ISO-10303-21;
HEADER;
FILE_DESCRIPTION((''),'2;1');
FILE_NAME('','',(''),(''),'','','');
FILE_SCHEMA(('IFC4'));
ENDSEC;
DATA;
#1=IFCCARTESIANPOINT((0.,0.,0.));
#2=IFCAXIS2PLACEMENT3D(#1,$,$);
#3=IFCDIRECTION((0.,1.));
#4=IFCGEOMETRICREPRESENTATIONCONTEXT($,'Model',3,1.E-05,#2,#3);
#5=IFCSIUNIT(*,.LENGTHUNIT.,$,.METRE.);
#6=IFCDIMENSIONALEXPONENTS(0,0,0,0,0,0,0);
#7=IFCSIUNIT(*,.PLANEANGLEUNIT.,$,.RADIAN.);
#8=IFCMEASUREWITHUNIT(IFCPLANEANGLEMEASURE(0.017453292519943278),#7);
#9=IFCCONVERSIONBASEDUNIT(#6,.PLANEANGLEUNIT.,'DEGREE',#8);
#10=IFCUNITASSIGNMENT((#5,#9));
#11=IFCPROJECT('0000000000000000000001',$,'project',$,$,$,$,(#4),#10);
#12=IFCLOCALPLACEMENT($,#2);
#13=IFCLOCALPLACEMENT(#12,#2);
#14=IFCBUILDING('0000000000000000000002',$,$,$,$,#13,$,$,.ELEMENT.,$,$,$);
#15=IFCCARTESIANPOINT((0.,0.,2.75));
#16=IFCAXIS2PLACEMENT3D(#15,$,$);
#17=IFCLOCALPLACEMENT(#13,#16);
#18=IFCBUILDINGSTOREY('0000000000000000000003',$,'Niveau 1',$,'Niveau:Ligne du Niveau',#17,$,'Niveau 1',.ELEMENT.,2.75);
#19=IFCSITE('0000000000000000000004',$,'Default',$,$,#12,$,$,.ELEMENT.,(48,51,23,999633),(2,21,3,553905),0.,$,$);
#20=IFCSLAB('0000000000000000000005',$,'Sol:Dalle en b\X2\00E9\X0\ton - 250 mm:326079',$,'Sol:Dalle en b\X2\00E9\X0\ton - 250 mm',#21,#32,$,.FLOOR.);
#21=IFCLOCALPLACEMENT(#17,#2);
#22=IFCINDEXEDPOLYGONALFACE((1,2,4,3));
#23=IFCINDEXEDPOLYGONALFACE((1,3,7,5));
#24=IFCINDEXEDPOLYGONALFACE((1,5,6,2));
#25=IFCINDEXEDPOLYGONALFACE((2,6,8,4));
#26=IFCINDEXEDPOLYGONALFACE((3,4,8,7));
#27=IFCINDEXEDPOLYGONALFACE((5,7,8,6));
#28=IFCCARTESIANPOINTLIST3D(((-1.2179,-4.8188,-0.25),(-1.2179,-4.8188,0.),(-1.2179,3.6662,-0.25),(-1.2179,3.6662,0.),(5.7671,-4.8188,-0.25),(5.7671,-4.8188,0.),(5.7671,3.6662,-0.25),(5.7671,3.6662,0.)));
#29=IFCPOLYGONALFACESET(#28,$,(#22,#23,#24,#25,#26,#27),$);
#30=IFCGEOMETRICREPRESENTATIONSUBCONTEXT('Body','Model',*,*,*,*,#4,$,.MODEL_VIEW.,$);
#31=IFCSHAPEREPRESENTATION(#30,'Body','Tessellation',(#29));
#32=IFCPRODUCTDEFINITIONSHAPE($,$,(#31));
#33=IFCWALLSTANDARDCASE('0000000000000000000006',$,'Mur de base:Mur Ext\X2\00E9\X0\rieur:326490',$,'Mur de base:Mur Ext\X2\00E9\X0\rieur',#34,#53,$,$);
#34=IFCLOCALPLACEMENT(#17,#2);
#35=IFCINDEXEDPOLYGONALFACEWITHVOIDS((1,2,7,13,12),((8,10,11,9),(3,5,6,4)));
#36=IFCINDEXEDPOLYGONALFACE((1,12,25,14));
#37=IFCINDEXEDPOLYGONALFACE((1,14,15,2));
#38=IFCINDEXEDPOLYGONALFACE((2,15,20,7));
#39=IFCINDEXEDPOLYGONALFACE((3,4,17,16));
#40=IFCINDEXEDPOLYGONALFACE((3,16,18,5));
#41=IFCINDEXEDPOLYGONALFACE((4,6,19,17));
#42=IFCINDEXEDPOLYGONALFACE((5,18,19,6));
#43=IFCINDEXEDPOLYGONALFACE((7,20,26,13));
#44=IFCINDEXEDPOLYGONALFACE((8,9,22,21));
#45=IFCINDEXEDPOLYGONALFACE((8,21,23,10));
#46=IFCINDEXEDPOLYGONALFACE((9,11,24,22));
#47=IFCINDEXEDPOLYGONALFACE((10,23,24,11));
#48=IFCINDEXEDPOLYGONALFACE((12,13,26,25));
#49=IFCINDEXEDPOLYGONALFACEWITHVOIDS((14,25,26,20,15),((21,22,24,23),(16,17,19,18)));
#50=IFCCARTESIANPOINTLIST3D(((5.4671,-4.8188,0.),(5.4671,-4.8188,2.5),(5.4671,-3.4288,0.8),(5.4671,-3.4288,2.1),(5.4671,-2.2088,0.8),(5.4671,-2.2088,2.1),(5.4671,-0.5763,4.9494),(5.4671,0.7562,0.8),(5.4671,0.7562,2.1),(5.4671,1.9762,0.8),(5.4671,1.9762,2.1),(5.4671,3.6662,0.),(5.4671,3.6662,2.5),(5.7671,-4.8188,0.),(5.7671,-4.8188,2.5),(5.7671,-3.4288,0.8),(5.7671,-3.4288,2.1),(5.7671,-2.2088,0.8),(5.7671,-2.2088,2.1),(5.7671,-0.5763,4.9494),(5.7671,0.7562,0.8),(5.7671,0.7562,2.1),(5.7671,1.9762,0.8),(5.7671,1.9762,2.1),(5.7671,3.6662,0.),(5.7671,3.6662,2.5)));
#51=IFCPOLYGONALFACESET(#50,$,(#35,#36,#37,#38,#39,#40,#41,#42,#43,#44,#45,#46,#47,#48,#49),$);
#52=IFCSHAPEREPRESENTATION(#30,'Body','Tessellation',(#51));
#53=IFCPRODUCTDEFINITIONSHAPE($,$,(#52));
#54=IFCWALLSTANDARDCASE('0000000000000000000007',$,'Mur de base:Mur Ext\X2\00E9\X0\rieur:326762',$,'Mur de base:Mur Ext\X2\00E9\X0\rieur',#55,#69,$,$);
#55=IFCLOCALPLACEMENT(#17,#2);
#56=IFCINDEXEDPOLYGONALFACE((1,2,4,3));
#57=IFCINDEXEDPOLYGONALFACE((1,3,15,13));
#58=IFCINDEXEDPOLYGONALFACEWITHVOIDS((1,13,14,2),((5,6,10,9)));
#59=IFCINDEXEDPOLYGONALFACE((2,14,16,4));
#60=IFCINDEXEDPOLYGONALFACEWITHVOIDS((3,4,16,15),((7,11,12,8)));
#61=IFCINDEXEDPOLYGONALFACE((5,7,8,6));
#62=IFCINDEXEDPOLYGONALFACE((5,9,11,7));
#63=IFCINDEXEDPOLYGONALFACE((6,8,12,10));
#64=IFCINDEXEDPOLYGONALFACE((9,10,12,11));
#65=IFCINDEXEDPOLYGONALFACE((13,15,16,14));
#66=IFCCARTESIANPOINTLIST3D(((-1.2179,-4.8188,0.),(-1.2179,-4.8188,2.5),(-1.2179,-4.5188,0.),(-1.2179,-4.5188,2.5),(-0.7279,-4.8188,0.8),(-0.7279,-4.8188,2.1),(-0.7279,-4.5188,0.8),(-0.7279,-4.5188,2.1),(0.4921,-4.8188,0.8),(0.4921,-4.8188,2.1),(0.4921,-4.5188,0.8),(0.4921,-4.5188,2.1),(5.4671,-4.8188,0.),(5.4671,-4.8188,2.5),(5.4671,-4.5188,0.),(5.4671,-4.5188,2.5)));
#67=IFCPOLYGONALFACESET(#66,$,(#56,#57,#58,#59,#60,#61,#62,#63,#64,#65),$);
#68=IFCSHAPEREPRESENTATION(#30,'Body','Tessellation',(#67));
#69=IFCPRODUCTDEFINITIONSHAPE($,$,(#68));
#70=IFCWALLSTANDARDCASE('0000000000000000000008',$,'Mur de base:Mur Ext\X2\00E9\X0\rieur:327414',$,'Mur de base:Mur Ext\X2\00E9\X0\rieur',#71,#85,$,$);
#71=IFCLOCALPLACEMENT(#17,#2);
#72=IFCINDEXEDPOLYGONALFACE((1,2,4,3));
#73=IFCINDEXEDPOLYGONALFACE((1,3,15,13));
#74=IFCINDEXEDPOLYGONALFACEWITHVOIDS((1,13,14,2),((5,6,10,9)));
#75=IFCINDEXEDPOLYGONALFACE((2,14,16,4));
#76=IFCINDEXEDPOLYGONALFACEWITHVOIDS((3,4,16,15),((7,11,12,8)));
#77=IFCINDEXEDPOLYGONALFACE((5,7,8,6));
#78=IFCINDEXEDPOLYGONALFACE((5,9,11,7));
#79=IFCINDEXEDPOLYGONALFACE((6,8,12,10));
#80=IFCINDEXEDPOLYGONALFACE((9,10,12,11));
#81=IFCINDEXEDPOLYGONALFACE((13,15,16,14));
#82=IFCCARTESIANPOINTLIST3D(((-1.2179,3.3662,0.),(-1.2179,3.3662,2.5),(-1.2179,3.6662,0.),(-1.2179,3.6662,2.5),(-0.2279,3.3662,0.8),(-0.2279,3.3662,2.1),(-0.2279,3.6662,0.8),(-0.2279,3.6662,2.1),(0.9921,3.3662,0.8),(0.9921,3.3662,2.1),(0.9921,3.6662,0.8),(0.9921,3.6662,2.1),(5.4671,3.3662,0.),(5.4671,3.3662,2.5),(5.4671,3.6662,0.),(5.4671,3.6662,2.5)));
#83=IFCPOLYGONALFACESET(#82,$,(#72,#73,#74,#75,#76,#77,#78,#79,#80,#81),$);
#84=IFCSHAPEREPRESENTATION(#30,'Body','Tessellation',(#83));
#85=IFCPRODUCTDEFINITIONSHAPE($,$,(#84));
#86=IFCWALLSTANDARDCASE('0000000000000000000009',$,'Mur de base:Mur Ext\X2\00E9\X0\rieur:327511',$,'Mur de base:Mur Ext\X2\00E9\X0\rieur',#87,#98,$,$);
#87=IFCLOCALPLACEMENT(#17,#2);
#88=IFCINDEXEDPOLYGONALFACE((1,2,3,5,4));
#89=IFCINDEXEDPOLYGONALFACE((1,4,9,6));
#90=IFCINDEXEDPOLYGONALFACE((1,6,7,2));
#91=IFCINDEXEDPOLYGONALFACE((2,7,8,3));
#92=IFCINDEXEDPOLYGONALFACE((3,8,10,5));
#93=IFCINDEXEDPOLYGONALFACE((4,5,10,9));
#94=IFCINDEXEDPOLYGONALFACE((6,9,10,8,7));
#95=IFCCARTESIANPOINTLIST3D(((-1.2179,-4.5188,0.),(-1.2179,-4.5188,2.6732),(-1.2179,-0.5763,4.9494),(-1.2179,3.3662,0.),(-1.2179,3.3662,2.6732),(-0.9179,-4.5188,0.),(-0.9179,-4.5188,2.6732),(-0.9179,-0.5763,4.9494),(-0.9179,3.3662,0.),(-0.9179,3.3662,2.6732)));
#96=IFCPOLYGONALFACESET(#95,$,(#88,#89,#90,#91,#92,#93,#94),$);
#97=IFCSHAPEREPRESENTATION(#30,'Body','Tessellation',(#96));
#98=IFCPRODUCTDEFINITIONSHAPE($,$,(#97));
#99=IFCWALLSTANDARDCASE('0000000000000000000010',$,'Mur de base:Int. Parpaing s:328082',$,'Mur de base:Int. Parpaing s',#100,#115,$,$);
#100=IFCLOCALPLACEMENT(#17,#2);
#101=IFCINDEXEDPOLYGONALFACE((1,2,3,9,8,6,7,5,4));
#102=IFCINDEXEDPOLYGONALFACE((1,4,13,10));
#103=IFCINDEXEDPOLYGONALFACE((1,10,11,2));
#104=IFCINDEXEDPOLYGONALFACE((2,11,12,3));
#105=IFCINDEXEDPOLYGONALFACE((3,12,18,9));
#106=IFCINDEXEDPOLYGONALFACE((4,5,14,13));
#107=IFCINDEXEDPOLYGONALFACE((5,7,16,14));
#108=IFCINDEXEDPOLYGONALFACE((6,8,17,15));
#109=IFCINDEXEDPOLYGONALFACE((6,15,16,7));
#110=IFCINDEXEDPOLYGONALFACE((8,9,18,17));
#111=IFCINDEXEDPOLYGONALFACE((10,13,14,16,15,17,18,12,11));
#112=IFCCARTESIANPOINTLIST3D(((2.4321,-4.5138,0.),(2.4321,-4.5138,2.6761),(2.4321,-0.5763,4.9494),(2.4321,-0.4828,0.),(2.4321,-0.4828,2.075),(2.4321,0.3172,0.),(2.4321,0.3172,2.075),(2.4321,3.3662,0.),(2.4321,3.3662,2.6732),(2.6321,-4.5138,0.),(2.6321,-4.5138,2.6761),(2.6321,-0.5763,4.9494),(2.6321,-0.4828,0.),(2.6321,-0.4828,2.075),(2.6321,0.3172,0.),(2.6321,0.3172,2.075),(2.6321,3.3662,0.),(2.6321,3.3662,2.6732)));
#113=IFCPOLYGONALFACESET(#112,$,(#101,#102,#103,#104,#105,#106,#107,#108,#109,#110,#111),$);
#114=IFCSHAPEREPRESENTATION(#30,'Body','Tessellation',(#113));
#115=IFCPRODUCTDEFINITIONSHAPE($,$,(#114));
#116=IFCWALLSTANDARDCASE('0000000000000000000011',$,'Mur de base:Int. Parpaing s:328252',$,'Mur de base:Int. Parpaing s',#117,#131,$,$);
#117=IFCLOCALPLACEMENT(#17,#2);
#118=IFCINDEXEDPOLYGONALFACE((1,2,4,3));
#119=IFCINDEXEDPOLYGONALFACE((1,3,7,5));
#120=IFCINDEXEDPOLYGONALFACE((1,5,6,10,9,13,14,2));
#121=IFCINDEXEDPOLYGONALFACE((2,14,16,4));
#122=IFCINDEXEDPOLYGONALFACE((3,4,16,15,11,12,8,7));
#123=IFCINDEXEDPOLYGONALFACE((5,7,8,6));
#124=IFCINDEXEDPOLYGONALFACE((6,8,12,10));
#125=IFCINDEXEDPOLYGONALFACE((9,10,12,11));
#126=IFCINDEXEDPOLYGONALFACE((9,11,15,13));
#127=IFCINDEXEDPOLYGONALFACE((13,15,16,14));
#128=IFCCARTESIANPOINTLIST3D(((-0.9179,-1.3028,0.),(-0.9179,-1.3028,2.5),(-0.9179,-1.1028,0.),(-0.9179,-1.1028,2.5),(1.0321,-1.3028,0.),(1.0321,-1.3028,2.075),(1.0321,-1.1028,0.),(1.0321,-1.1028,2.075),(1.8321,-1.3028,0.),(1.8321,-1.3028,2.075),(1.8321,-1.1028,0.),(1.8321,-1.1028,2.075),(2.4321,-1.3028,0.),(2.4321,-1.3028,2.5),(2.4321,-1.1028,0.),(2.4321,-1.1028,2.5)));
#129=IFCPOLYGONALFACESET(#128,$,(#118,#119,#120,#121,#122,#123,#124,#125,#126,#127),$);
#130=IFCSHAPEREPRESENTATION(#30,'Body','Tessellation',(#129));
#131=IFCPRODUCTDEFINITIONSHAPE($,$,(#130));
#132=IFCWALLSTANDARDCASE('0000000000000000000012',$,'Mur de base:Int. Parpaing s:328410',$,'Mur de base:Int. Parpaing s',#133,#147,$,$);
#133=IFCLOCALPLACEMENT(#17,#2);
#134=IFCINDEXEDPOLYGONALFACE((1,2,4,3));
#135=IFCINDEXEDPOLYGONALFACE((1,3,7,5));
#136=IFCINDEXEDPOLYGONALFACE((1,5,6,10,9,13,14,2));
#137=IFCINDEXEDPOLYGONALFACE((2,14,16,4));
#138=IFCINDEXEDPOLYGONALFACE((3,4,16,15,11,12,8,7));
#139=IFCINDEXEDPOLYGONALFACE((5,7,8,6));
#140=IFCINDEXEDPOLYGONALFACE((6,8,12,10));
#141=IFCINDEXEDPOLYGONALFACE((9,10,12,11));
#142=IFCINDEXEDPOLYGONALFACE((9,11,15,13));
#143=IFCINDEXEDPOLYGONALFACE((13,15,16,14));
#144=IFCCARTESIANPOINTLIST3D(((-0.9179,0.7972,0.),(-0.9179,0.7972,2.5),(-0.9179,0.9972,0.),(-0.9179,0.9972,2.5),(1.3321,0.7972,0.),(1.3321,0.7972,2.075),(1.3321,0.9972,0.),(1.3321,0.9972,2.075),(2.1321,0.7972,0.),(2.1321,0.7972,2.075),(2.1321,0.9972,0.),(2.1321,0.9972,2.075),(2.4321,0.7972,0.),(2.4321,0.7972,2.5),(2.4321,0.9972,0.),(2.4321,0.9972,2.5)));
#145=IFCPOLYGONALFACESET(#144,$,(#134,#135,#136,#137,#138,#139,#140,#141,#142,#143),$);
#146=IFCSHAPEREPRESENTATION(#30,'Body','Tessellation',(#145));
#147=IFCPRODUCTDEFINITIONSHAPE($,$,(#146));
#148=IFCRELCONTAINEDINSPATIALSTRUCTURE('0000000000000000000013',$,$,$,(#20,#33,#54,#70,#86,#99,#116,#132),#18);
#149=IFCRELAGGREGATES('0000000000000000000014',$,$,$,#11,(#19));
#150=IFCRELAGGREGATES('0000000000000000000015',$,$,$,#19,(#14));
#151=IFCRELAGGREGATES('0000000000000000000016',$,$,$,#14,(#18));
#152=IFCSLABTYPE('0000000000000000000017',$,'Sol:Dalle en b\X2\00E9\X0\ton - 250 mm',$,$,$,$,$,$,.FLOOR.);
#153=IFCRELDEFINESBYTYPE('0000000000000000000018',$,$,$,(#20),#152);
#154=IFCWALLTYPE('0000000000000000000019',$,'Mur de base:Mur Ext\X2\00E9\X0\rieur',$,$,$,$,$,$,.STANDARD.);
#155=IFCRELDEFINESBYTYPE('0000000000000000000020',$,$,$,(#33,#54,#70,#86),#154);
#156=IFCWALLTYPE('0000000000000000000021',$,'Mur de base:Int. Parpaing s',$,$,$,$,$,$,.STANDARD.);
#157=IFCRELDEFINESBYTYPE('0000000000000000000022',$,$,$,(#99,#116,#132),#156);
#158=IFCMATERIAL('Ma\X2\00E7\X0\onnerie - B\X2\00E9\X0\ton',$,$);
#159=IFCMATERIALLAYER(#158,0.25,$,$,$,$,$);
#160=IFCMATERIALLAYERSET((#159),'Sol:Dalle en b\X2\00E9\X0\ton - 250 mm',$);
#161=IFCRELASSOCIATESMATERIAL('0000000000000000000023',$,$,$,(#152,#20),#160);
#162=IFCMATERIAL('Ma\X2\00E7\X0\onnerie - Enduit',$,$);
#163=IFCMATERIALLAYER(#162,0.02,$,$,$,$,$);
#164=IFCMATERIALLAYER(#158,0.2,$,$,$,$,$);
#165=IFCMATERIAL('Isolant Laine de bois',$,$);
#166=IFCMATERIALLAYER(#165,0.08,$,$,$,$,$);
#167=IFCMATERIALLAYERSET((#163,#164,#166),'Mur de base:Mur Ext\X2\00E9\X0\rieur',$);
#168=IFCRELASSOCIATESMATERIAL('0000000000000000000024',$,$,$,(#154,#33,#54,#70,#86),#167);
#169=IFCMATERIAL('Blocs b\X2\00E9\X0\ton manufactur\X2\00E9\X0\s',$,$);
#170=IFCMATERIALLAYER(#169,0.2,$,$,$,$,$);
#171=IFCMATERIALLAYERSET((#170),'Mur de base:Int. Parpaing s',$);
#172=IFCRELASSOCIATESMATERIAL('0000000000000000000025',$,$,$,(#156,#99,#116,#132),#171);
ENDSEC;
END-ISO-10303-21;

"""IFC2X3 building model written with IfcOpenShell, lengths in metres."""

from ifc_helpers import new_model, entity, si_unit, converted_unit, direction, frame, frame_2d, origin, origin_2d_with_axis, place, context, subcontext, project, spatial, polyline, rectangle, extrude, clip, bounded_halfspace, material, layer, layer_set, layer_usage, type_object, element, save


model = new_model("IFC2X3")

# Units and contexts
model_context = context("Model", 3, precision=1e-05, world=origin(), true_north=direction((0.0, 1.0)))
body_context = subcontext(model_context, "Body", "Model", "MODEL_VIEW")
ifc_project = project(units=[si_unit("LENGTHUNIT", "METRE"), converted_unit("PLANEANGLEUNIT", "DEGREE", entity("IfcPlaneAngleMeasure", 0.017453292519943278), si_unit("PLANEANGLEUNIT", "RADIAN"), dimensions=[0, 0, 0, 0, 0, 0, 0])], contexts=[model_context])

# Site, building, storey
site_placement = place(None, origin())
site = spatial("IfcSite", under=ifc_project, at=site_placement, Name="Default", CompositionType="ELEMENT", RefLatitude=(48, 51, 23, 999633), RefLongitude=(2, 21, 3, 553905), RefElevation=0.0)
building_placement = place(site_placement, origin())
building = spatial("IfcBuilding", under=site, at=building_placement, CompositionType="ELEMENT")
storey_placement = place(building_placement, frame((0.0, 0.0, 2.75)))
storey = spatial("IfcBuildingStorey", under=building, at=storey_placement, Name="Niveau 1", ObjectType="Niveau:Ligne du Niveau", LongName="Niveau 1", CompositionType="ELEMENT", Elevation=2.75)

# Slab
ifc_material_1 = material(Name="Maçonnerie - Béton")
ifc_layer_1 = layer(ifc_material_1, 0.25)
ifc_layer_set_1 = layer_set([ifc_layer_1], Name="Sol:Dalle en béton - 250 mm")
ifc_layer_usage_1 = layer_usage(ifc_layer_set_1, "AXIS3", "POSITIVE", 0.0)
slab_type = type_object("IfcSlabType", Name="Sol:Dalle en béton - 250 mm", PredefinedType="FLOOR", material=ifc_layer_set_1)
slab_placement = place(storey_placement, origin())
element("IfcSlab", 1, at=slab_placement, inside=storey, type_object=slab_type, material=ifc_layer_usage_1, Name="Sol:Dalle en béton - 250 mm:326079", ObjectType="Sol:Dalle en béton - 250 mm", PredefinedType="FLOOR", context=body_context, shape_type="SweptSolid", body=[
    extrude(rectangle(XDim=8.485, YDim=6.985, at=origin_2d_with_axis()), frame((2.2746, -0.5763, 0.0), z_axis=(0.0, 0.0, -1.0), x_axis=(0.0, 1.0, 0.0)), (0.0, 0.0, 1.0), 0.25),
])

# Wall, openings
ifc_material_2 = material(Name="Maçonnerie - Enduit")
ifc_layer_2 = layer(ifc_material_2, 0.02)
ifc_layer_3 = layer(ifc_material_1, 0.2)
ifc_material_3 = material(Name="Isolant Laine de bois")
ifc_layer_4 = layer(ifc_material_3, 0.08)
ifc_layer_set_2 = layer_set([ifc_layer_2, ifc_layer_3, ifc_layer_4], Name="Mur de base:Mur Extérieur")
ifc_layer_usage_2 = layer_usage(ifc_layer_set_2, "AXIS2", "NEGATIVE", 0.15)
wall_type_1 = type_object("IfcWallType", Name="Mur de base:Mur Extérieur", PredefinedType="STANDARD", material=ifc_layer_set_2)
wall_1_placement = place(storey_placement, frame((5.6171, 3.6662, 0.0), z_axis=(0.0, 0.0, 1.0), x_axis=(0.0, -1.0, 0.0)))
wall_1 = element("IfcWallStandardCase", 2, at=wall_1_placement, inside=storey, type_object=wall_type_1, material=ifc_layer_usage_2, Name="Mur de base:Mur Extérieur:326490", ObjectType="Mur de base:Mur Extérieur", context=body_context, shape_type="Clipping", body=[
    clip(clip(extrude(rectangle(XDim=8.485, YDim=0.3, at=frame_2d((4.2425, 0.0), x_axis=(-1.0, 0.0))), origin(), (0.0, 0.0, 1.0), 4.9494), bounded_halfspace(frame((4.2425, -0.15, 4.9494), z_axis=(0.5, 0.0, 0.866025), x_axis=(0.0, 1.0, 0.0)), False, frame((4.2425, -0.15, 4.9494)), polyline([(0.0, 0.0), (4.2425, 0.0), (4.2425, 0.3), (0.0, 0.3), (0.0, 0.0)]))), bounded_halfspace(frame((0.0, -0.15, 2.5), z_axis=(-0.5, 0.0, 0.866025), x_axis=(0.0, -1.0, 0.0)), False, frame((0.0, -0.15, 2.5)), polyline([(0.0, 0.0), (4.2425, 0.0), (4.2425, 0.3), (0.0, 0.3), (0.0, 0.0)]))),
])
opening_1_placement = place(wall_1_placement, frame((2.91, 0.15, 0.8)))
element("IfcOpeningElement", 3, at=opening_1_placement, cuts=wall_1, ObjectType="Opening", context=body_context, shape_type="SweptSolid", body=[
    extrude(rectangle(XDim=1.3, YDim=1.22, at=frame_2d((0.65, 0.61), x_axis=(1.0, 0.0))), frame((0.0, 0.0, 0.0), z_axis=(0.0, -1.0, 0.0), x_axis=(0.0, 0.0, 1.0)), (0.0, 0.0, 1.0), 0.3),
])
opening_2_placement = place(wall_1_placement, frame((5.875, -0.15, 0.8)))
element("IfcOpeningElement", 4, at=opening_2_placement, cuts=wall_1, ObjectType="Opening", context=body_context, shape_type="SweptSolid", body=[
    extrude(rectangle(XDim=1.3, YDim=1.22, at=frame_2d((0.65, 0.61), x_axis=(1.0, 0.0))), frame((0.0, 0.0, 0.0), z_axis=(0.0, 1.0, 0.0), x_axis=(0.0, 0.0, 1.0)), (0.0, 0.0, 1.0), 0.3),
])

# Walls, openings
ifc_layer_usage_3 = layer_usage(ifc_layer_set_2, "AXIS2", "NEGATIVE", 0.15)
wall_2_placement = place(storey_placement, frame((5.4671, -4.6688, 0.0), z_axis=(0.0, 0.0, 1.0), x_axis=(-1.0, 0.0, 0.0)))
wall_2 = element("IfcWallStandardCase", 5, at=wall_2_placement, inside=storey, type_object=wall_type_1, material=ifc_layer_usage_3, Name="Mur de base:Mur Extérieur:326762", ObjectType="Mur de base:Mur Extérieur", context=body_context, shape_type="SweptSolid", body=[
    extrude(rectangle(XDim=6.685, YDim=0.3, at=frame_2d((3.3425, 0.0), x_axis=(-1.0, 0.0))), origin(), (0.0, 0.0, 1.0), 2.5),
])
opening_3_placement = place(wall_2_placement, frame((4.975, -0.15, 0.8)))
element("IfcOpeningElement", 6, at=opening_3_placement, cuts=wall_2, ObjectType="Opening", context=body_context, shape_type="SweptSolid", body=[
    extrude(rectangle(XDim=1.3, YDim=1.22, at=frame_2d((0.65, 0.61), x_axis=(1.0, 0.0))), frame((0.0, 0.0, 0.0), z_axis=(0.0, 1.0, 0.0), x_axis=(0.0, 0.0, 1.0)), (0.0, 0.0, 1.0), 0.3),
])
ifc_layer_usage_4 = layer_usage(ifc_layer_set_2, "AXIS2", "POSITIVE", -0.15)
wall_3_placement = place(storey_placement, frame((5.4671, 3.5162, 0.0), z_axis=(0.0, 0.0, 1.0), x_axis=(-1.0, 0.0, 0.0)))
wall_3 = element("IfcWallStandardCase", 7, at=wall_3_placement, inside=storey, type_object=wall_type_1, material=ifc_layer_usage_4, Name="Mur de base:Mur Extérieur:327414", ObjectType="Mur de base:Mur Extérieur", context=body_context, shape_type="SweptSolid", body=[
    extrude(rectangle(XDim=6.685, YDim=0.3, at=frame_2d((3.3425, 0.0), x_axis=(-1.0, 0.0))), origin(), (0.0, 0.0, 1.0), 2.5),
])
opening_4_placement = place(wall_3_placement, frame((5.695, 0.15, 0.8)))
element("IfcOpeningElement", 8, at=opening_4_placement, cuts=wall_3, ObjectType="Opening", context=body_context, shape_type="SweptSolid", body=[
    extrude(rectangle(XDim=1.3, YDim=1.22, at=frame_2d((0.65, 0.61), x_axis=(1.0, 0.0))), frame((0.0, 0.0, 0.0), z_axis=(0.0, -1.0, 0.0), x_axis=(0.0, 0.0, 1.0)), (0.0, 0.0, 1.0), 0.3),
])

# Wall
ifc_layer_usage_5 = layer_usage(ifc_layer_set_2, "AXIS2", "POSITIVE", -0.15)
wall_4_placement = place(storey_placement, frame((-1.0679, 3.3662, 0.0), z_axis=(0.0, 0.0, 1.0), x_axis=(0.0, -1.0, 0.0)))
element("IfcWallStandardCase", 9, at=wall_4_placement, inside=storey, type_object=wall_type_1, material=ifc_layer_usage_5, Name="Mur de base:Mur Extérieur:327511", ObjectType="Mur de base:Mur Extérieur", context=body_context, shape_type="Clipping", body=[
    clip(clip(extrude(rectangle(XDim=7.885, YDim=0.3, at=frame_2d((3.9425, 0.0), x_axis=(-1.0, 0.0))), origin(), (0.0, 0.0, 1.0), 4.9494), bounded_halfspace(frame((3.9425, -0.15, 4.9494), z_axis=(0.5, 0.0, 0.866025), x_axis=(0.0, 1.0, 0.0)), False, frame((3.9425, -0.15, 4.9494)), polyline([(0.0, 0.0), (3.9425, 0.0), (3.9425, 0.3), (0.0, 0.3), (0.0, 0.0)]))), bounded_halfspace(frame((0.0, -0.15, 2.6732), z_axis=(-0.5, 0.0, 0.866025), x_axis=(0.0, -1.0, 0.0)), False, frame((0.0, -0.15, 2.6732)), polyline([(0.0, 0.0), (3.9425, 0.0), (3.9425, 0.3), (0.0, 0.3), (0.0, 0.0)]))),
])

# Walls, openings
ifc_material_4 = material(Name="Blocs béton manufacturés")
ifc_layer_5 = layer(ifc_material_4, 0.2)
ifc_layer_set_3 = layer_set([ifc_layer_5], Name="Mur de base:Int. Parpaing s")
ifc_layer_usage_6 = layer_usage(ifc_layer_set_3, "AXIS2", "NEGATIVE", 0.1)
wall_type_2 = type_object("IfcWallType", Name="Mur de base:Int. Parpaing s", PredefinedType="STANDARD", material=ifc_layer_set_3)
wall_5_placement = place(storey_placement, frame((2.5321, 3.3662, 0.0), z_axis=(0.0, 0.0, 1.0), x_axis=(0.0, -1.0, 0.0)))
wall_5 = element("IfcWallStandardCase", 10, at=wall_5_placement, inside=storey, type_object=wall_type_2, material=ifc_layer_usage_6, Name="Mur de base:Int. Parpaing s:328082", ObjectType="Mur de base:Int. Parpaing s", context=body_context, shape_type="Clipping", body=[
    clip(clip(extrude(rectangle(XDim=7.88, YDim=0.2, at=frame_2d((3.94, 0.0), x_axis=(-1.0, 0.0))), origin(), (0.0, 0.0, 1.0), 4.9494), bounded_halfspace(frame((7.88, -0.1, 2.6761), z_axis=(0.5, 0.0, 0.866025), x_axis=(0.0, 1.0, 0.0)), False, frame((7.88, -0.1, 2.6761)), polyline([(0.0, 0.0), (0.0, 0.2), (-3.9375, 0.2), (-3.9375, 0.0), (0.0, 0.0)]))), bounded_halfspace(frame((0.0, 0.1, 2.6732), z_axis=(-0.5, 0.0, 0.866025), x_axis=(0.0, -1.0, 0.0)), False, frame((0.0, 0.1, 2.6732)), polyline([(0.0, 0.0), (0.0, -0.2), (3.9425, -0.2), (3.9425, 0.0), (0.0, 0.0)]))),
])
opening_5_placement = place(wall_5_placement, frame((3.0489, -0.1, 0.0)))
element("IfcOpeningElement", 11, at=opening_5_placement, cuts=wall_5, ObjectType="Opening", context=body_context, shape_type="SweptSolid", body=[
    extrude(rectangle(XDim=2.075, YDim=0.8, at=frame_2d((1.0375, 0.4), x_axis=(1.0, 0.0))), frame((0.0, 0.0, 0.0), z_axis=(0.0, 1.0, 0.0), x_axis=(0.0, 0.0, 1.0)), (0.0, 0.0, 1.0), 0.2),
])
ifc_layer_usage_7 = layer_usage(ifc_layer_set_3, "AXIS2", "NEGATIVE", 0.1)
wall_6_placement = place(storey_placement, frame((-0.9179, -1.2028, 0.0)))
wall_6 = element("IfcWallStandardCase", 12, at=wall_6_placement, inside=storey, type_object=wall_type_2, material=ifc_layer_usage_7, Name="Mur de base:Int. Parpaing s:328252", ObjectType="Mur de base:Int. Parpaing s", context=body_context, shape_type="SweptSolid", body=[
    extrude(rectangle(XDim=3.35, YDim=0.2, at=frame_2d((1.675, 0.0), x_axis=(1.0, 0.0))), origin(), (0.0, 0.0, 1.0), 2.5),
])
opening_6_placement = place(wall_6_placement, frame((2.75, 0.1, 0.0)))
element("IfcOpeningElement", 13, at=opening_6_placement, cuts=wall_6, ObjectType="Opening", context=body_context, shape_type="SweptSolid", body=[
    extrude(rectangle(XDim=2.075, YDim=0.8, at=frame_2d((1.0375, 0.4), x_axis=(1.0, 0.0))), frame((0.0, 0.0, 0.0), z_axis=(0.0, -1.0, 0.0), x_axis=(0.0, 0.0, 1.0)), (0.0, 0.0, 1.0), 0.2),
])
ifc_layer_usage_8 = layer_usage(ifc_layer_set_3, "AXIS2", "NEGATIVE", 0.1)
wall_7_placement = place(storey_placement, frame((-0.9179, 0.8972, 0.0)))
wall_7 = element("IfcWallStandardCase", 14, at=wall_7_placement, inside=storey, type_object=wall_type_2, material=ifc_layer_usage_8, Name="Mur de base:Int. Parpaing s:328410", ObjectType="Mur de base:Int. Parpaing s", context=body_context, shape_type="SweptSolid", body=[
    extrude(rectangle(XDim=3.35, YDim=0.2, at=frame_2d((1.675, 0.0), x_axis=(-1.0, 0.0))), origin(), (0.0, 0.0, 1.0), 2.5),
])
opening_7_placement = place(wall_7_placement, frame((2.25, -0.1, 0.0)))
element("IfcOpeningElement", 15, at=opening_7_placement, cuts=wall_7, ObjectType="Opening", context=body_context, shape_type="SweptSolid", body=[
    extrude(rectangle(XDim=2.075, YDim=0.8, at=frame_2d((1.0375, 0.4), x_axis=(1.0, 0.0))), frame((0.0, 0.0, 0.0), z_axis=(0.0, 1.0, 0.0), x_axis=(0.0, 0.0, 1.0)), (0.0, 0.0, 1.0), 0.2),
])

save(model, "model.ifc")
